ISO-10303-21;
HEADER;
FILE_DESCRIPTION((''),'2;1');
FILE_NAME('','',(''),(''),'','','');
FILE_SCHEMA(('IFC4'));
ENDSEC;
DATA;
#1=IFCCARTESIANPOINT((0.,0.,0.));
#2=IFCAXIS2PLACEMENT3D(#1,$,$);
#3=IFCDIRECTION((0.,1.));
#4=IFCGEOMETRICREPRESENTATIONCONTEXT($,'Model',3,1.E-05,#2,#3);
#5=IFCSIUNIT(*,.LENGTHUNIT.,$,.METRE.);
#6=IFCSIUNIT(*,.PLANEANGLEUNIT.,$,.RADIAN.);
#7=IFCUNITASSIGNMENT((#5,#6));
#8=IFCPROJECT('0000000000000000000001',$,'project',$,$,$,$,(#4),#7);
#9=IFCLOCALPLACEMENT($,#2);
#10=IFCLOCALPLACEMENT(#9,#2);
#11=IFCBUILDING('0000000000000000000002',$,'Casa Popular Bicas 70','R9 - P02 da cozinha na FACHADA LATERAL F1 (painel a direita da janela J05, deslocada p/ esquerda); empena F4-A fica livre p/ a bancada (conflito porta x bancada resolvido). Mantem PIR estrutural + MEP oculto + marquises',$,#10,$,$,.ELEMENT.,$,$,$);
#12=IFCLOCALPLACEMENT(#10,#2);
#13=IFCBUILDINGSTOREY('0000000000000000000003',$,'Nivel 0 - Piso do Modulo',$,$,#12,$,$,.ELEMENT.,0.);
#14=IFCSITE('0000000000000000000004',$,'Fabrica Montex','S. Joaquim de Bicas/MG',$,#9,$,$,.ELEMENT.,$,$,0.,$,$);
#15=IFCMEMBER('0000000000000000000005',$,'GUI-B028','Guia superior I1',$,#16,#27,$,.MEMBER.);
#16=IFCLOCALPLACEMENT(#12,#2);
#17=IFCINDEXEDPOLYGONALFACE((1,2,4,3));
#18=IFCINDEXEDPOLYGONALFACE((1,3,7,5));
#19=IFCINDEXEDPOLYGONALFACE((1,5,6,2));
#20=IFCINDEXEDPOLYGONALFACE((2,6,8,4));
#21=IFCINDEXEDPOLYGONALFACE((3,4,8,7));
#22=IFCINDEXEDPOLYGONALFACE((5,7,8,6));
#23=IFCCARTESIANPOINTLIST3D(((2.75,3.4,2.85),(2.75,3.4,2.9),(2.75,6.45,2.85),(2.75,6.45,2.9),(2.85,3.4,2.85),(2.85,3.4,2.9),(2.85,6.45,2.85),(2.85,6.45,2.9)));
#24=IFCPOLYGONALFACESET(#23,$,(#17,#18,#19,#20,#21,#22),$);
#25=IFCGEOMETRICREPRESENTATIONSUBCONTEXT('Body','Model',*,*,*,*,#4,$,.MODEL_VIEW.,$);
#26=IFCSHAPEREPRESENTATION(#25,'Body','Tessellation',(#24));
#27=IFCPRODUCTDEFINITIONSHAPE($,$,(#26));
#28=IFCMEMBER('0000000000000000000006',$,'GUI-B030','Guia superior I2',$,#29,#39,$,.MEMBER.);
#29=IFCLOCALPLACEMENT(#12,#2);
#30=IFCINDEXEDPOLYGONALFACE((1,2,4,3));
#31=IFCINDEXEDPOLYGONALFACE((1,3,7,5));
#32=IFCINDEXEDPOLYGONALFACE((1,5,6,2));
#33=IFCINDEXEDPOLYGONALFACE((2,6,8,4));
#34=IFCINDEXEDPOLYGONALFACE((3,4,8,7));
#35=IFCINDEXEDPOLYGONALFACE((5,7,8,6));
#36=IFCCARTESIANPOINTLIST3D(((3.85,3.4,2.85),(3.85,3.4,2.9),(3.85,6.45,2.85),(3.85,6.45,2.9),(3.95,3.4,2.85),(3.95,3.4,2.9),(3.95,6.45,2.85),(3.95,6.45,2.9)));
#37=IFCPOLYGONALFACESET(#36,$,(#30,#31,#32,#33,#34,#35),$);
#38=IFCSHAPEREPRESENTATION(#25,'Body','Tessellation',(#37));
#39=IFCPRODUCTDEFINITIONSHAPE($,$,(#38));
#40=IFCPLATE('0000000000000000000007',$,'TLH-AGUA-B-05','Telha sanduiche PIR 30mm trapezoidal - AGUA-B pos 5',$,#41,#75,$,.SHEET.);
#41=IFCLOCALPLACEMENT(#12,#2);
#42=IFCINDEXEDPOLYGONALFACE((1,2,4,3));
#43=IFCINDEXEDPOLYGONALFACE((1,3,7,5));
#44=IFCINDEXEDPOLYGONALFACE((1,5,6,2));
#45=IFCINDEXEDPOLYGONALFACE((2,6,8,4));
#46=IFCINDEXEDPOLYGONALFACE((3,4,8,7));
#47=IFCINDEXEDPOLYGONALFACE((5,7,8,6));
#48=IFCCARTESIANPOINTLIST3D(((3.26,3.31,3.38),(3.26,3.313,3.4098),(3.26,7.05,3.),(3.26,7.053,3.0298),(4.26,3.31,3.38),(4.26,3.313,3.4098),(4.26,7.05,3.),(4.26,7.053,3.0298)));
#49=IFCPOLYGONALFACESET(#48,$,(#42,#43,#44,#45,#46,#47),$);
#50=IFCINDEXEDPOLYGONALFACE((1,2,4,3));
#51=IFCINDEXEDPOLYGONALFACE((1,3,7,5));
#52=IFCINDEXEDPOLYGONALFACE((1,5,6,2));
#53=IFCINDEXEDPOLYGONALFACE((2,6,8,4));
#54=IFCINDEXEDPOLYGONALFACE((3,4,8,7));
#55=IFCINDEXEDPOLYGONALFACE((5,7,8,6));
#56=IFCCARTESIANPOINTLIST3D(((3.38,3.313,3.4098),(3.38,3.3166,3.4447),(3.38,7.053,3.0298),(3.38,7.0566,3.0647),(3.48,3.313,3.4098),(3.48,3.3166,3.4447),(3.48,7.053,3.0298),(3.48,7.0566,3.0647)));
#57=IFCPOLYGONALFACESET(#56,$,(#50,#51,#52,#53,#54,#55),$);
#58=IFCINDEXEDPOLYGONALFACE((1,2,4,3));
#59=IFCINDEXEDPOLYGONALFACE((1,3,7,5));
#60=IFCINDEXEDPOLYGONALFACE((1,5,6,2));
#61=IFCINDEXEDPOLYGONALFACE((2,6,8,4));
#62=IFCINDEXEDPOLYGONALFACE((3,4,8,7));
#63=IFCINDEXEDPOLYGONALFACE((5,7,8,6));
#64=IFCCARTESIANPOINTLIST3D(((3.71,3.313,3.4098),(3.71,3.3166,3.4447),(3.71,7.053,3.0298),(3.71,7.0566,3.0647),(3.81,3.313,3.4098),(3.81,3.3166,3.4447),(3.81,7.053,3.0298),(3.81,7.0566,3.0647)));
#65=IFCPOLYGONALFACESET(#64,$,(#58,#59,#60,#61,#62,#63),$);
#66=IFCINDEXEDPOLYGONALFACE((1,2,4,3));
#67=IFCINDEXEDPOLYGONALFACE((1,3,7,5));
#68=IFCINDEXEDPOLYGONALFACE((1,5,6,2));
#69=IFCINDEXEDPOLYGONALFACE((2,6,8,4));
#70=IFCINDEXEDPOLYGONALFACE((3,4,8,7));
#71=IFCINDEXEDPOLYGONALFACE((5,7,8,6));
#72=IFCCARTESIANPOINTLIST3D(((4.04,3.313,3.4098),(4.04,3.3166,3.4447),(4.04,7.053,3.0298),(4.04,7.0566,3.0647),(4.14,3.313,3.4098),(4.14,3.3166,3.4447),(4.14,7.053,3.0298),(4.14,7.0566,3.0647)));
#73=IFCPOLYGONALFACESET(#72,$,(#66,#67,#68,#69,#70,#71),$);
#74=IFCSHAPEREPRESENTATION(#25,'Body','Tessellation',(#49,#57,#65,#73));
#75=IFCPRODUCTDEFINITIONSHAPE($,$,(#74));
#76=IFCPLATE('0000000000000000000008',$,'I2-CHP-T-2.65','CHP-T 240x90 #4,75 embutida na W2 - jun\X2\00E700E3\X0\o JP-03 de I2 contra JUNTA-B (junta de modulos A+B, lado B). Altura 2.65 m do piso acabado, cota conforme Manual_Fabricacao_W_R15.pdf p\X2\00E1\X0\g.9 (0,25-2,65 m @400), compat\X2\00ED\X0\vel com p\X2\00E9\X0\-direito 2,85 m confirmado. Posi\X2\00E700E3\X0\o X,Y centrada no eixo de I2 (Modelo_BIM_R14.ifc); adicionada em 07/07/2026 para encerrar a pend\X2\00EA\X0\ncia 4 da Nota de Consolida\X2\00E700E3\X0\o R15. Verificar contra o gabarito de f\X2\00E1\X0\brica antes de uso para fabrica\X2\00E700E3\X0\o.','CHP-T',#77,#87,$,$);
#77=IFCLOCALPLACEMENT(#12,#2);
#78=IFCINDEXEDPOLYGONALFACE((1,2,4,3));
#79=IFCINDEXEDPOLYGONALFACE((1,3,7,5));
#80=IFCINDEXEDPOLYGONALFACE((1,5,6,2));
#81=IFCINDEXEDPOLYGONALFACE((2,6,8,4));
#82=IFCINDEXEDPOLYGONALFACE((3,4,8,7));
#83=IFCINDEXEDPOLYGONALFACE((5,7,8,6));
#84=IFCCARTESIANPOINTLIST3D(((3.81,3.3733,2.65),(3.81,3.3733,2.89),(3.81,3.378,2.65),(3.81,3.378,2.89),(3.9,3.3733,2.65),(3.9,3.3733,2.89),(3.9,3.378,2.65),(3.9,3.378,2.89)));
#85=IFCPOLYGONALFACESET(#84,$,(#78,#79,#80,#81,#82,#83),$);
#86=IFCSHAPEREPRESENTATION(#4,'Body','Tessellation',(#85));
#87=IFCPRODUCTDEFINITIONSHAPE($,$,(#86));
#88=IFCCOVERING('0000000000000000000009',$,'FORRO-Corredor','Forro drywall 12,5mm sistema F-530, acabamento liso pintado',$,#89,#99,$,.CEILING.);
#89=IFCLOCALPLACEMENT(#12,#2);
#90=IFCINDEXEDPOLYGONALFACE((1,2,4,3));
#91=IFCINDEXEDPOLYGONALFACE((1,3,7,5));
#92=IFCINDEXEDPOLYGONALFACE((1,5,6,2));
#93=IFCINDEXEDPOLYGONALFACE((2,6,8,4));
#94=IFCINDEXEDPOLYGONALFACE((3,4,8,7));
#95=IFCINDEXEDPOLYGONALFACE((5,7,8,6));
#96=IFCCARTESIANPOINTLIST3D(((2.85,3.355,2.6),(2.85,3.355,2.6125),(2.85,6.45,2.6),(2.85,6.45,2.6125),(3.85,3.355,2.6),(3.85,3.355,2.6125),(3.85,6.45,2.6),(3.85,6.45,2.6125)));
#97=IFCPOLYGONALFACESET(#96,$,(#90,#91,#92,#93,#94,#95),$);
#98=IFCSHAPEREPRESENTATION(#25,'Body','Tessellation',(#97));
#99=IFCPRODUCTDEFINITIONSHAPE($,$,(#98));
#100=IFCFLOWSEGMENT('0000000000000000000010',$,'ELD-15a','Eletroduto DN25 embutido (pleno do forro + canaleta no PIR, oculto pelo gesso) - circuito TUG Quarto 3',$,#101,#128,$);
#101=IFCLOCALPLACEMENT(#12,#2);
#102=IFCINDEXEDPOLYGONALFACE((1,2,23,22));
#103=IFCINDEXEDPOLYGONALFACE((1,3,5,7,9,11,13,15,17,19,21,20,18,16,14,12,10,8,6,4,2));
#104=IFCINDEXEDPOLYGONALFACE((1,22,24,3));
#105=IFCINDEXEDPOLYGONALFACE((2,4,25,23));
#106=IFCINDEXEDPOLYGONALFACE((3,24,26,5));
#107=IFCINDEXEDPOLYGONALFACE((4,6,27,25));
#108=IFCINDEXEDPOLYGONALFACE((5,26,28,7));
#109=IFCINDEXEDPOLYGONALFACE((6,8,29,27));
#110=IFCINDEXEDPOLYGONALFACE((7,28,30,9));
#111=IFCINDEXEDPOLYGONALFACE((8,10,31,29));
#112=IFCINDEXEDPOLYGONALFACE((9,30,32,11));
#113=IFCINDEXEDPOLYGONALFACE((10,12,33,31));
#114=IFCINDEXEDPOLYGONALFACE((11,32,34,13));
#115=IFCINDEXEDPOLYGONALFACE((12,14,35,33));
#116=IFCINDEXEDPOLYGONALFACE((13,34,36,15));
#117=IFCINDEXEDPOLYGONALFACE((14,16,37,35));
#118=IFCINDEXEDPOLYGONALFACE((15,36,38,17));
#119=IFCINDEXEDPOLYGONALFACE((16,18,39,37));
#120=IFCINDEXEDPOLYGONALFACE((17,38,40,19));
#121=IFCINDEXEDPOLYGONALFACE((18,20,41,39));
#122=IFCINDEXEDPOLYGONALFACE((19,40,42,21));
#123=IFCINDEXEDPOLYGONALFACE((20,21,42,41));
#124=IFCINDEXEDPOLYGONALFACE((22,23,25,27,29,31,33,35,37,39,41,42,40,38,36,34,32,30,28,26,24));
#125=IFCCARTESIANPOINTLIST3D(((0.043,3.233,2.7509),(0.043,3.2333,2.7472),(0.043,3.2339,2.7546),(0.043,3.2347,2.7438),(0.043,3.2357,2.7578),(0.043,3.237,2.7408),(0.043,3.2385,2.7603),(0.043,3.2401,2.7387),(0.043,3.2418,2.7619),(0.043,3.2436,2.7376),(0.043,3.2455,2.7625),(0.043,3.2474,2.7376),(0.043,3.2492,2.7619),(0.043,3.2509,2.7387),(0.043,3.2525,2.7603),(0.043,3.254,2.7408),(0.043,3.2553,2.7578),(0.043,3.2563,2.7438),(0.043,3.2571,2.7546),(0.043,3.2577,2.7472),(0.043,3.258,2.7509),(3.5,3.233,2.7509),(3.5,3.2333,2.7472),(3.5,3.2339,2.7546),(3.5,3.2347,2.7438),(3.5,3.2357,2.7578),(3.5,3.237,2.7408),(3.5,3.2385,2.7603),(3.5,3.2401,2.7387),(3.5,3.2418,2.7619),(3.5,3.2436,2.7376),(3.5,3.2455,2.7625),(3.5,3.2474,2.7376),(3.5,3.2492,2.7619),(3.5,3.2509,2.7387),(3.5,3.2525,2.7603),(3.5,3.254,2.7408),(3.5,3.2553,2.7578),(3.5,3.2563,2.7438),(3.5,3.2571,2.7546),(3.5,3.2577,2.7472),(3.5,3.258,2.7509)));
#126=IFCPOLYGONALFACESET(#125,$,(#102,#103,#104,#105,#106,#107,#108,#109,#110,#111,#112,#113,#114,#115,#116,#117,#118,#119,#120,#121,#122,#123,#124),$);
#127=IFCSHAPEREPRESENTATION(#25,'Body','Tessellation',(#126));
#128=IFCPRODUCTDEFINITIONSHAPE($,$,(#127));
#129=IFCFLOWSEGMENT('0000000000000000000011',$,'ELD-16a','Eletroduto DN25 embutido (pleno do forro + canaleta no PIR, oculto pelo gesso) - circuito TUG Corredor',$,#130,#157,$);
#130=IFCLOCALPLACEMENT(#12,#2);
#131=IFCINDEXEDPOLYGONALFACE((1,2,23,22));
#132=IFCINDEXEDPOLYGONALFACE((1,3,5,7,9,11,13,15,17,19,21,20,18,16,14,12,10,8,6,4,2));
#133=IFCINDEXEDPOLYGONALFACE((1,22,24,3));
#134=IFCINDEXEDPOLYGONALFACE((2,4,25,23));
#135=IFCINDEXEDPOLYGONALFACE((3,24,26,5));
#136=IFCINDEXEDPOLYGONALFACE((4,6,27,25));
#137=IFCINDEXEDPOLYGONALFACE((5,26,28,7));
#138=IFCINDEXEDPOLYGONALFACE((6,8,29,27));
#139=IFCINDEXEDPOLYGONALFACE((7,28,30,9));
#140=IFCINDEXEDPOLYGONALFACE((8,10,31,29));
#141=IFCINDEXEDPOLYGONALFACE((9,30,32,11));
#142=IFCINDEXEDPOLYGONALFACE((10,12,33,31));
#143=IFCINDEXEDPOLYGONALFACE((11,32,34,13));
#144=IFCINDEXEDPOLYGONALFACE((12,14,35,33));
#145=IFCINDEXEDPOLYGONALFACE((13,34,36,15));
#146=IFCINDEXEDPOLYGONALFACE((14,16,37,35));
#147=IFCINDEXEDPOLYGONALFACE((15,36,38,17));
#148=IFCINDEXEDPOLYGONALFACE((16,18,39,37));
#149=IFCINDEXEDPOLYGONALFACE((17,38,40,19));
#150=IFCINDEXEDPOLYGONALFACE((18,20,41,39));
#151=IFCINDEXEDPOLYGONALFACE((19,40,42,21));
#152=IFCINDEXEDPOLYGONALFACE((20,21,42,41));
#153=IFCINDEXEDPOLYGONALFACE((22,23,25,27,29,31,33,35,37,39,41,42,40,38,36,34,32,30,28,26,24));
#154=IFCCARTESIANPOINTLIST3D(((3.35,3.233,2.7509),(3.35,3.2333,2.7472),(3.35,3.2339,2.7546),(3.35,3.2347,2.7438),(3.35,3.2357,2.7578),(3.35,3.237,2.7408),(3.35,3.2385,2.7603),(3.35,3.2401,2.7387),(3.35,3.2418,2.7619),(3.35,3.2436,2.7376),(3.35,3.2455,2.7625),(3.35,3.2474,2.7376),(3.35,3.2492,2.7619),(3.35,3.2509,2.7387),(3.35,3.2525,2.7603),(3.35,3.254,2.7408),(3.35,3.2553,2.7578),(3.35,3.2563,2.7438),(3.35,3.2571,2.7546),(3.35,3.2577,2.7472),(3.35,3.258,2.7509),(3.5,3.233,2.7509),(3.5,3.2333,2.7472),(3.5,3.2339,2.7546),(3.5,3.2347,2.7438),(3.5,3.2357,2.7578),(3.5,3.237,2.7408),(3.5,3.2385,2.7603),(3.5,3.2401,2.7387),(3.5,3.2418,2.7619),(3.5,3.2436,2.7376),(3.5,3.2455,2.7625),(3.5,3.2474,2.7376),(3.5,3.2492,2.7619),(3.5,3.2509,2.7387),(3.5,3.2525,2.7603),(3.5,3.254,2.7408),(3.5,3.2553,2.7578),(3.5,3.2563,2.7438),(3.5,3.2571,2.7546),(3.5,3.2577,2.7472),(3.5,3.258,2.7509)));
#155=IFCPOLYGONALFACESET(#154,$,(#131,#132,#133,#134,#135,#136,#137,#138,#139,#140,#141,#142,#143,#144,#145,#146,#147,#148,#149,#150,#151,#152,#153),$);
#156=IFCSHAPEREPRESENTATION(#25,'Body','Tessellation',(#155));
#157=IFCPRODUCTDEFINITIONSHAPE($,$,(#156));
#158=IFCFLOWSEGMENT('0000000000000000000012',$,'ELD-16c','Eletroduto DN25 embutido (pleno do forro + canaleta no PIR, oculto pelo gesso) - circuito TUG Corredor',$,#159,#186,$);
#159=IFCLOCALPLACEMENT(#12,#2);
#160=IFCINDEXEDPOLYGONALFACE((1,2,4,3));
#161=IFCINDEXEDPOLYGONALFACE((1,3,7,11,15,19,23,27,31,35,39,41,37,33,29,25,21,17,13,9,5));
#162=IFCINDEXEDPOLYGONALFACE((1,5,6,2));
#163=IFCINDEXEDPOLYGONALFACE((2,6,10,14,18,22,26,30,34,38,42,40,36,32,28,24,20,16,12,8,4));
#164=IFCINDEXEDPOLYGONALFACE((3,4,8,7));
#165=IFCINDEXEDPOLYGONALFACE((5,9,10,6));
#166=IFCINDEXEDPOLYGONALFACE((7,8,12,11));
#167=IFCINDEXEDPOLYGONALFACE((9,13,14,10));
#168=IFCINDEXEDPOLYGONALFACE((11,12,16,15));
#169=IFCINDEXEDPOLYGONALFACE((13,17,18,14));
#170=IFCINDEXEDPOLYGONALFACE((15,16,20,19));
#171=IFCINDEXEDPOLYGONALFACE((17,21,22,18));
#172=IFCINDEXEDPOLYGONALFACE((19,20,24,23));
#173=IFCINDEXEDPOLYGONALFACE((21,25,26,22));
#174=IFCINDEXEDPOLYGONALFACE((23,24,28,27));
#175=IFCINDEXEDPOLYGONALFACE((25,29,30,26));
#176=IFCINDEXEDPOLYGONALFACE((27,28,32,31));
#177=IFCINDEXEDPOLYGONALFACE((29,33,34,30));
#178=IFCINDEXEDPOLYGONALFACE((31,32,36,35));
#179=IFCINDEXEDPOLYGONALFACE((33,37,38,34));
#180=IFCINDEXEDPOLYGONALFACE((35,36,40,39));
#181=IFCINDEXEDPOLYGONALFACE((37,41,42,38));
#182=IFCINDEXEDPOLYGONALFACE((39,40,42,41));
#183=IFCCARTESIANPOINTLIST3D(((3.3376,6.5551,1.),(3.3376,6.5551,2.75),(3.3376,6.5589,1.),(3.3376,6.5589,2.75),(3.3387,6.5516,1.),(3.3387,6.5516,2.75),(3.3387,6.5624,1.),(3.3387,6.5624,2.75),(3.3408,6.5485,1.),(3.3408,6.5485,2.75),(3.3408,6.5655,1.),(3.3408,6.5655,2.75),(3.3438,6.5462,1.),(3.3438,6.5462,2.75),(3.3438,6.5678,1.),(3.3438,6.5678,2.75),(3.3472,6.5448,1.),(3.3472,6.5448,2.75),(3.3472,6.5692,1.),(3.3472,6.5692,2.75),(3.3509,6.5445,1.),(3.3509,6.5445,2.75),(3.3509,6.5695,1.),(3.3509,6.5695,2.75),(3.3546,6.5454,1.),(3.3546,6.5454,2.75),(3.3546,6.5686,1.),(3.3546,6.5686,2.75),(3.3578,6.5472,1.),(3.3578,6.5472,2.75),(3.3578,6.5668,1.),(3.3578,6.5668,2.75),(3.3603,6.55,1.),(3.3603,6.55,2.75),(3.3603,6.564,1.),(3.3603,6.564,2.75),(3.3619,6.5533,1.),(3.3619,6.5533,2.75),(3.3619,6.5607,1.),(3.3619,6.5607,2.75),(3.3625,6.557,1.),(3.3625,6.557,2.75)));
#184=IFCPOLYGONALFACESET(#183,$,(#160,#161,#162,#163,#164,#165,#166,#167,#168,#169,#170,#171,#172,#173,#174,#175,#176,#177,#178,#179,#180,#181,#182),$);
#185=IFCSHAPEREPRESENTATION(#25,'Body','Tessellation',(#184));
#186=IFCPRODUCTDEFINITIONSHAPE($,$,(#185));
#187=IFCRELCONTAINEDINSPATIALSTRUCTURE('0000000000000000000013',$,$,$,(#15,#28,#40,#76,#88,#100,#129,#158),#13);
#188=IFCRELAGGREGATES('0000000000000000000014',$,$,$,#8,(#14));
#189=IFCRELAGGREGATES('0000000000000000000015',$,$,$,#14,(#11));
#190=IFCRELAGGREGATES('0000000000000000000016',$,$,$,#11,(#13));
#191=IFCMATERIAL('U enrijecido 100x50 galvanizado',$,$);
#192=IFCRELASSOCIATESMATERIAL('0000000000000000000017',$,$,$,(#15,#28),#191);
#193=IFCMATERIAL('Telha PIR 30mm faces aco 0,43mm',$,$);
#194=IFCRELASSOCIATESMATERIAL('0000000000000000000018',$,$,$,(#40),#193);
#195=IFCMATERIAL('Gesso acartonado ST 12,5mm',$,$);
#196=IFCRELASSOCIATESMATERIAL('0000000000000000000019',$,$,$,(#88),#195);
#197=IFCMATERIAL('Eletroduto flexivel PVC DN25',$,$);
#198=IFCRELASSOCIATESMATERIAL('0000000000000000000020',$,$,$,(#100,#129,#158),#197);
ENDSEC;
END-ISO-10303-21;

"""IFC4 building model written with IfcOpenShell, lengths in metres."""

from ifc_helpers import new_model, si_unit, direction, frame, frame_2d, origin, origin_with_axes, origin_2d, place, context, subcontext, project, spatial, rectangle, circle, extrude, material, element, save


model = new_model("IFC4")

# Units and contexts
model_context = context("Model", 3, precision=1e-05, world=origin(), true_north=direction((0.0, 1.0)))
body_context = subcontext(model_context, "Body", "Model", "MODEL_VIEW")
ifc_project = project(units=[si_unit("LENGTHUNIT", "METRE"), si_unit("PLANEANGLEUNIT", "RADIAN")], contexts=[model_context])

# Site, building, storey
site_placement = place(None, origin())
site = spatial("IfcSite", under=ifc_project, at=site_placement, Name="Fabrica Montex", Description="S. Joaquim de Bicas/MG", CompositionType="ELEMENT", RefElevation=0.0)
building_placement = place(site_placement, origin())
building = spatial("IfcBuilding", under=site, at=building_placement, Name="Casa Popular Bicas 70", Description="R9 - P02 da cozinha na FACHADA LATERAL F1 (painel a direita da janela J05, deslocada p/ esquerda); empena F4-A fica livre p/ a bancada (conflito porta x bancada resolvido). Mantem PIR estrutural + MEP oculto + marquises", CompositionType="ELEMENT")
storey_placement = place(building_placement, origin())
storey = spatial("IfcBuildingStorey", under=building, at=storey_placement, Name="Nivel 0 - Piso do Modulo", CompositionType="ELEMENT", Elevation=0.0)

# Members
ifc_material_1 = material(Name="U enrijecido 100x50 galvanizado")
for number, where, z_axis, x_axis, name, description in (
    (1, (2.8, 3.4, 2.875), (0.0, 1.0, 0.0), (0.0, 0.0, 1.0), "GUI-B028", "Guia superior I1"),
    (2, (3.9, 3.4, 2.875), (0.0, 1.0, 0.0), (0.0, 0.0, 1.0), "GUI-B030", "Guia superior I2"),
):
    element("IfcMember", number, at=place(storey_placement, frame(where, z_axis=z_axis, x_axis=x_axis)), inside=storey, material=ifc_material_1, Name=name, Description=description, PredefinedType="MEMBER", context=body_context, shape_type="SweptSolid", body=[
        extrude(rectangle(XDim=0.05, YDim=0.1, at=origin_2d()), origin(), (0.0, 0.0, 1.0), 3.05),
    ])

# Plates
ifc_material_2 = material(Name="Telha PIR 30mm faces aco 0,43mm")
plate_1_placement = place(storey_placement, frame((3.26, 3.31, 3.38), z_axis=(0.0, 0.101084, 0.994878), x_axis=(1.0, 0.0, 0.0)))
element("IfcPlate", 3, at=plate_1_placement, inside=storey, material=ifc_material_2, Name="TLH-AGUA-B-05", Description="Telha sanduiche PIR 30mm trapezoidal - AGUA-B pos 5", PredefinedType="SHEET", context=body_context, shape_type="SweptSolid", body=[
    extrude(rectangle(XDim=1.0, YDim=3.7593, at=frame_2d((0.5, 1.8796))), origin(), (0.0, 0.0, 1.0), 0.03),
    extrude(rectangle(XDim=0.1, YDim=3.7593, at=frame_2d((0.17, 1.8796))), frame((0.0, 0.0, 0.03)), (0.0, 0.0, 1.0), 0.035),
    extrude(rectangle(XDim=0.1, YDim=3.7593, at=frame_2d((0.5, 1.8796))), frame((0.0, 0.0, 0.03)), (0.0, 0.0, 1.0), 0.035),
    extrude(rectangle(XDim=0.1, YDim=3.7593, at=frame_2d((0.83, 1.8796))), frame((0.0, 0.0, 0.03)), (0.0, 0.0, 1.0), 0.035),
])
plate_2_placement = place(storey_placement, frame((3.855, 3.3756, 2.65), z_axis=(0.0, 0.0, 1.0), x_axis=(1.0, 0.0, 0.0)))
element("IfcPlate", 4, at=plate_2_placement, inside=storey, Name="I2-CHP-T-2.65", Description="CHP-T 240x90 #4,75 embutida na W2 - junção JP-03 de I2 contra JUNTA-B (junta de modulos A+B, lado B). Altura 2.65 m do piso acabado, cota conforme Manual_Fabricacao_W_R15.pdf pág.9 (0,25-2,65 m @400), compatível com pé-direito 2,85 m confirmado. Posição X,Y centrada no eixo de I2 (Modelo_BIM_R14.ifc); adicionada em 07/07/2026 para encerrar a pendência 4 da Nota de Consolidação R15. Verificar contra o gabarito de fábrica antes de uso para fabricação.", ObjectType="CHP-T", context=model_context, shape_type="SweptSolid", body=[
    extrude(rectangle(XDim=0.09, YDim=0.0047, at=origin_2d()), origin_with_axes(), (0.0, 0.0, 1.0), 0.24),
])

# Covering
ifc_material_3 = material(Name="Gesso acartonado ST 12,5mm")
covering_placement = place(storey_placement, frame((2.85, 3.355, 2.6)))
element("IfcCovering", 5, at=covering_placement, inside=storey, material=ifc_material_3, Name="FORRO-Corredor", Description="Forro drywall 12,5mm sistema F-530, acabamento liso pintado", PredefinedType="CEILING", context=body_context, shape_type="SweptSolid", body=[
    extrude(rectangle(XDim=1.0, YDim=3.095, at=frame_2d((0.5, 1.5475))), origin(), (0.0, 0.0, 1.0), 0.0125),
])

# Flow segments
ifc_material_4 = material(Name="Eletroduto flexivel PVC DN25")
flow_segment_1_placement = place(storey_placement, frame((3.5, 3.2455, 2.75), z_axis=(-1.0, 0.0, 0.0), x_axis=(0.0, 0.0, 1.0)))
element("IfcFlowSegment", 6, at=flow_segment_1_placement, inside=storey, material=ifc_material_4, Name="ELD-15a", Description="Eletroduto DN25 embutido (pleno do forro + canaleta no PIR, oculto pelo gesso) - circuito TUG Quarto 3", context=body_context, shape_type="SweptSolid", body=[
    extrude(circle(Radius=0.0125, at=origin_2d()), origin(), (0.0, 0.0, 1.0), 3.457),
])
flow_segment_2_placement = place(storey_placement, frame((3.5, 3.2455, 2.75), z_axis=(-1.0, 0.0, 0.0), x_axis=(0.0, 0.0, 1.0)))
element("IfcFlowSegment", 7, at=flow_segment_2_placement, inside=storey, material=ifc_material_4, Name="ELD-16a", Description="Eletroduto DN25 embutido (pleno do forro + canaleta no PIR, oculto pelo gesso) - circuito TUG Corredor", context=body_context, shape_type="SweptSolid", body=[
    extrude(circle(Radius=0.0125, at=origin_2d()), origin(), (0.0, 0.0, 1.0), 0.15),
])
flow_segment_3_placement = place(storey_placement, frame((3.35, 6.557, 2.75), z_axis=(0.0, 0.0, -1.0), x_axis=(1.0, 0.0, 0.0)))
element("IfcFlowSegment", 8, at=flow_segment_3_placement, inside=storey, material=ifc_material_4, Name="ELD-16c", Description="Eletroduto DN25 embutido (pleno do forro + canaleta no PIR, oculto pelo gesso) - circuito TUG Corredor", context=body_context, shape_type="SweptSolid", body=[
    extrude(circle(Radius=0.0125, at=origin_2d()), origin(), (0.0, 0.0, 1.0), 1.75),
])

save(model, "model.ifc")
